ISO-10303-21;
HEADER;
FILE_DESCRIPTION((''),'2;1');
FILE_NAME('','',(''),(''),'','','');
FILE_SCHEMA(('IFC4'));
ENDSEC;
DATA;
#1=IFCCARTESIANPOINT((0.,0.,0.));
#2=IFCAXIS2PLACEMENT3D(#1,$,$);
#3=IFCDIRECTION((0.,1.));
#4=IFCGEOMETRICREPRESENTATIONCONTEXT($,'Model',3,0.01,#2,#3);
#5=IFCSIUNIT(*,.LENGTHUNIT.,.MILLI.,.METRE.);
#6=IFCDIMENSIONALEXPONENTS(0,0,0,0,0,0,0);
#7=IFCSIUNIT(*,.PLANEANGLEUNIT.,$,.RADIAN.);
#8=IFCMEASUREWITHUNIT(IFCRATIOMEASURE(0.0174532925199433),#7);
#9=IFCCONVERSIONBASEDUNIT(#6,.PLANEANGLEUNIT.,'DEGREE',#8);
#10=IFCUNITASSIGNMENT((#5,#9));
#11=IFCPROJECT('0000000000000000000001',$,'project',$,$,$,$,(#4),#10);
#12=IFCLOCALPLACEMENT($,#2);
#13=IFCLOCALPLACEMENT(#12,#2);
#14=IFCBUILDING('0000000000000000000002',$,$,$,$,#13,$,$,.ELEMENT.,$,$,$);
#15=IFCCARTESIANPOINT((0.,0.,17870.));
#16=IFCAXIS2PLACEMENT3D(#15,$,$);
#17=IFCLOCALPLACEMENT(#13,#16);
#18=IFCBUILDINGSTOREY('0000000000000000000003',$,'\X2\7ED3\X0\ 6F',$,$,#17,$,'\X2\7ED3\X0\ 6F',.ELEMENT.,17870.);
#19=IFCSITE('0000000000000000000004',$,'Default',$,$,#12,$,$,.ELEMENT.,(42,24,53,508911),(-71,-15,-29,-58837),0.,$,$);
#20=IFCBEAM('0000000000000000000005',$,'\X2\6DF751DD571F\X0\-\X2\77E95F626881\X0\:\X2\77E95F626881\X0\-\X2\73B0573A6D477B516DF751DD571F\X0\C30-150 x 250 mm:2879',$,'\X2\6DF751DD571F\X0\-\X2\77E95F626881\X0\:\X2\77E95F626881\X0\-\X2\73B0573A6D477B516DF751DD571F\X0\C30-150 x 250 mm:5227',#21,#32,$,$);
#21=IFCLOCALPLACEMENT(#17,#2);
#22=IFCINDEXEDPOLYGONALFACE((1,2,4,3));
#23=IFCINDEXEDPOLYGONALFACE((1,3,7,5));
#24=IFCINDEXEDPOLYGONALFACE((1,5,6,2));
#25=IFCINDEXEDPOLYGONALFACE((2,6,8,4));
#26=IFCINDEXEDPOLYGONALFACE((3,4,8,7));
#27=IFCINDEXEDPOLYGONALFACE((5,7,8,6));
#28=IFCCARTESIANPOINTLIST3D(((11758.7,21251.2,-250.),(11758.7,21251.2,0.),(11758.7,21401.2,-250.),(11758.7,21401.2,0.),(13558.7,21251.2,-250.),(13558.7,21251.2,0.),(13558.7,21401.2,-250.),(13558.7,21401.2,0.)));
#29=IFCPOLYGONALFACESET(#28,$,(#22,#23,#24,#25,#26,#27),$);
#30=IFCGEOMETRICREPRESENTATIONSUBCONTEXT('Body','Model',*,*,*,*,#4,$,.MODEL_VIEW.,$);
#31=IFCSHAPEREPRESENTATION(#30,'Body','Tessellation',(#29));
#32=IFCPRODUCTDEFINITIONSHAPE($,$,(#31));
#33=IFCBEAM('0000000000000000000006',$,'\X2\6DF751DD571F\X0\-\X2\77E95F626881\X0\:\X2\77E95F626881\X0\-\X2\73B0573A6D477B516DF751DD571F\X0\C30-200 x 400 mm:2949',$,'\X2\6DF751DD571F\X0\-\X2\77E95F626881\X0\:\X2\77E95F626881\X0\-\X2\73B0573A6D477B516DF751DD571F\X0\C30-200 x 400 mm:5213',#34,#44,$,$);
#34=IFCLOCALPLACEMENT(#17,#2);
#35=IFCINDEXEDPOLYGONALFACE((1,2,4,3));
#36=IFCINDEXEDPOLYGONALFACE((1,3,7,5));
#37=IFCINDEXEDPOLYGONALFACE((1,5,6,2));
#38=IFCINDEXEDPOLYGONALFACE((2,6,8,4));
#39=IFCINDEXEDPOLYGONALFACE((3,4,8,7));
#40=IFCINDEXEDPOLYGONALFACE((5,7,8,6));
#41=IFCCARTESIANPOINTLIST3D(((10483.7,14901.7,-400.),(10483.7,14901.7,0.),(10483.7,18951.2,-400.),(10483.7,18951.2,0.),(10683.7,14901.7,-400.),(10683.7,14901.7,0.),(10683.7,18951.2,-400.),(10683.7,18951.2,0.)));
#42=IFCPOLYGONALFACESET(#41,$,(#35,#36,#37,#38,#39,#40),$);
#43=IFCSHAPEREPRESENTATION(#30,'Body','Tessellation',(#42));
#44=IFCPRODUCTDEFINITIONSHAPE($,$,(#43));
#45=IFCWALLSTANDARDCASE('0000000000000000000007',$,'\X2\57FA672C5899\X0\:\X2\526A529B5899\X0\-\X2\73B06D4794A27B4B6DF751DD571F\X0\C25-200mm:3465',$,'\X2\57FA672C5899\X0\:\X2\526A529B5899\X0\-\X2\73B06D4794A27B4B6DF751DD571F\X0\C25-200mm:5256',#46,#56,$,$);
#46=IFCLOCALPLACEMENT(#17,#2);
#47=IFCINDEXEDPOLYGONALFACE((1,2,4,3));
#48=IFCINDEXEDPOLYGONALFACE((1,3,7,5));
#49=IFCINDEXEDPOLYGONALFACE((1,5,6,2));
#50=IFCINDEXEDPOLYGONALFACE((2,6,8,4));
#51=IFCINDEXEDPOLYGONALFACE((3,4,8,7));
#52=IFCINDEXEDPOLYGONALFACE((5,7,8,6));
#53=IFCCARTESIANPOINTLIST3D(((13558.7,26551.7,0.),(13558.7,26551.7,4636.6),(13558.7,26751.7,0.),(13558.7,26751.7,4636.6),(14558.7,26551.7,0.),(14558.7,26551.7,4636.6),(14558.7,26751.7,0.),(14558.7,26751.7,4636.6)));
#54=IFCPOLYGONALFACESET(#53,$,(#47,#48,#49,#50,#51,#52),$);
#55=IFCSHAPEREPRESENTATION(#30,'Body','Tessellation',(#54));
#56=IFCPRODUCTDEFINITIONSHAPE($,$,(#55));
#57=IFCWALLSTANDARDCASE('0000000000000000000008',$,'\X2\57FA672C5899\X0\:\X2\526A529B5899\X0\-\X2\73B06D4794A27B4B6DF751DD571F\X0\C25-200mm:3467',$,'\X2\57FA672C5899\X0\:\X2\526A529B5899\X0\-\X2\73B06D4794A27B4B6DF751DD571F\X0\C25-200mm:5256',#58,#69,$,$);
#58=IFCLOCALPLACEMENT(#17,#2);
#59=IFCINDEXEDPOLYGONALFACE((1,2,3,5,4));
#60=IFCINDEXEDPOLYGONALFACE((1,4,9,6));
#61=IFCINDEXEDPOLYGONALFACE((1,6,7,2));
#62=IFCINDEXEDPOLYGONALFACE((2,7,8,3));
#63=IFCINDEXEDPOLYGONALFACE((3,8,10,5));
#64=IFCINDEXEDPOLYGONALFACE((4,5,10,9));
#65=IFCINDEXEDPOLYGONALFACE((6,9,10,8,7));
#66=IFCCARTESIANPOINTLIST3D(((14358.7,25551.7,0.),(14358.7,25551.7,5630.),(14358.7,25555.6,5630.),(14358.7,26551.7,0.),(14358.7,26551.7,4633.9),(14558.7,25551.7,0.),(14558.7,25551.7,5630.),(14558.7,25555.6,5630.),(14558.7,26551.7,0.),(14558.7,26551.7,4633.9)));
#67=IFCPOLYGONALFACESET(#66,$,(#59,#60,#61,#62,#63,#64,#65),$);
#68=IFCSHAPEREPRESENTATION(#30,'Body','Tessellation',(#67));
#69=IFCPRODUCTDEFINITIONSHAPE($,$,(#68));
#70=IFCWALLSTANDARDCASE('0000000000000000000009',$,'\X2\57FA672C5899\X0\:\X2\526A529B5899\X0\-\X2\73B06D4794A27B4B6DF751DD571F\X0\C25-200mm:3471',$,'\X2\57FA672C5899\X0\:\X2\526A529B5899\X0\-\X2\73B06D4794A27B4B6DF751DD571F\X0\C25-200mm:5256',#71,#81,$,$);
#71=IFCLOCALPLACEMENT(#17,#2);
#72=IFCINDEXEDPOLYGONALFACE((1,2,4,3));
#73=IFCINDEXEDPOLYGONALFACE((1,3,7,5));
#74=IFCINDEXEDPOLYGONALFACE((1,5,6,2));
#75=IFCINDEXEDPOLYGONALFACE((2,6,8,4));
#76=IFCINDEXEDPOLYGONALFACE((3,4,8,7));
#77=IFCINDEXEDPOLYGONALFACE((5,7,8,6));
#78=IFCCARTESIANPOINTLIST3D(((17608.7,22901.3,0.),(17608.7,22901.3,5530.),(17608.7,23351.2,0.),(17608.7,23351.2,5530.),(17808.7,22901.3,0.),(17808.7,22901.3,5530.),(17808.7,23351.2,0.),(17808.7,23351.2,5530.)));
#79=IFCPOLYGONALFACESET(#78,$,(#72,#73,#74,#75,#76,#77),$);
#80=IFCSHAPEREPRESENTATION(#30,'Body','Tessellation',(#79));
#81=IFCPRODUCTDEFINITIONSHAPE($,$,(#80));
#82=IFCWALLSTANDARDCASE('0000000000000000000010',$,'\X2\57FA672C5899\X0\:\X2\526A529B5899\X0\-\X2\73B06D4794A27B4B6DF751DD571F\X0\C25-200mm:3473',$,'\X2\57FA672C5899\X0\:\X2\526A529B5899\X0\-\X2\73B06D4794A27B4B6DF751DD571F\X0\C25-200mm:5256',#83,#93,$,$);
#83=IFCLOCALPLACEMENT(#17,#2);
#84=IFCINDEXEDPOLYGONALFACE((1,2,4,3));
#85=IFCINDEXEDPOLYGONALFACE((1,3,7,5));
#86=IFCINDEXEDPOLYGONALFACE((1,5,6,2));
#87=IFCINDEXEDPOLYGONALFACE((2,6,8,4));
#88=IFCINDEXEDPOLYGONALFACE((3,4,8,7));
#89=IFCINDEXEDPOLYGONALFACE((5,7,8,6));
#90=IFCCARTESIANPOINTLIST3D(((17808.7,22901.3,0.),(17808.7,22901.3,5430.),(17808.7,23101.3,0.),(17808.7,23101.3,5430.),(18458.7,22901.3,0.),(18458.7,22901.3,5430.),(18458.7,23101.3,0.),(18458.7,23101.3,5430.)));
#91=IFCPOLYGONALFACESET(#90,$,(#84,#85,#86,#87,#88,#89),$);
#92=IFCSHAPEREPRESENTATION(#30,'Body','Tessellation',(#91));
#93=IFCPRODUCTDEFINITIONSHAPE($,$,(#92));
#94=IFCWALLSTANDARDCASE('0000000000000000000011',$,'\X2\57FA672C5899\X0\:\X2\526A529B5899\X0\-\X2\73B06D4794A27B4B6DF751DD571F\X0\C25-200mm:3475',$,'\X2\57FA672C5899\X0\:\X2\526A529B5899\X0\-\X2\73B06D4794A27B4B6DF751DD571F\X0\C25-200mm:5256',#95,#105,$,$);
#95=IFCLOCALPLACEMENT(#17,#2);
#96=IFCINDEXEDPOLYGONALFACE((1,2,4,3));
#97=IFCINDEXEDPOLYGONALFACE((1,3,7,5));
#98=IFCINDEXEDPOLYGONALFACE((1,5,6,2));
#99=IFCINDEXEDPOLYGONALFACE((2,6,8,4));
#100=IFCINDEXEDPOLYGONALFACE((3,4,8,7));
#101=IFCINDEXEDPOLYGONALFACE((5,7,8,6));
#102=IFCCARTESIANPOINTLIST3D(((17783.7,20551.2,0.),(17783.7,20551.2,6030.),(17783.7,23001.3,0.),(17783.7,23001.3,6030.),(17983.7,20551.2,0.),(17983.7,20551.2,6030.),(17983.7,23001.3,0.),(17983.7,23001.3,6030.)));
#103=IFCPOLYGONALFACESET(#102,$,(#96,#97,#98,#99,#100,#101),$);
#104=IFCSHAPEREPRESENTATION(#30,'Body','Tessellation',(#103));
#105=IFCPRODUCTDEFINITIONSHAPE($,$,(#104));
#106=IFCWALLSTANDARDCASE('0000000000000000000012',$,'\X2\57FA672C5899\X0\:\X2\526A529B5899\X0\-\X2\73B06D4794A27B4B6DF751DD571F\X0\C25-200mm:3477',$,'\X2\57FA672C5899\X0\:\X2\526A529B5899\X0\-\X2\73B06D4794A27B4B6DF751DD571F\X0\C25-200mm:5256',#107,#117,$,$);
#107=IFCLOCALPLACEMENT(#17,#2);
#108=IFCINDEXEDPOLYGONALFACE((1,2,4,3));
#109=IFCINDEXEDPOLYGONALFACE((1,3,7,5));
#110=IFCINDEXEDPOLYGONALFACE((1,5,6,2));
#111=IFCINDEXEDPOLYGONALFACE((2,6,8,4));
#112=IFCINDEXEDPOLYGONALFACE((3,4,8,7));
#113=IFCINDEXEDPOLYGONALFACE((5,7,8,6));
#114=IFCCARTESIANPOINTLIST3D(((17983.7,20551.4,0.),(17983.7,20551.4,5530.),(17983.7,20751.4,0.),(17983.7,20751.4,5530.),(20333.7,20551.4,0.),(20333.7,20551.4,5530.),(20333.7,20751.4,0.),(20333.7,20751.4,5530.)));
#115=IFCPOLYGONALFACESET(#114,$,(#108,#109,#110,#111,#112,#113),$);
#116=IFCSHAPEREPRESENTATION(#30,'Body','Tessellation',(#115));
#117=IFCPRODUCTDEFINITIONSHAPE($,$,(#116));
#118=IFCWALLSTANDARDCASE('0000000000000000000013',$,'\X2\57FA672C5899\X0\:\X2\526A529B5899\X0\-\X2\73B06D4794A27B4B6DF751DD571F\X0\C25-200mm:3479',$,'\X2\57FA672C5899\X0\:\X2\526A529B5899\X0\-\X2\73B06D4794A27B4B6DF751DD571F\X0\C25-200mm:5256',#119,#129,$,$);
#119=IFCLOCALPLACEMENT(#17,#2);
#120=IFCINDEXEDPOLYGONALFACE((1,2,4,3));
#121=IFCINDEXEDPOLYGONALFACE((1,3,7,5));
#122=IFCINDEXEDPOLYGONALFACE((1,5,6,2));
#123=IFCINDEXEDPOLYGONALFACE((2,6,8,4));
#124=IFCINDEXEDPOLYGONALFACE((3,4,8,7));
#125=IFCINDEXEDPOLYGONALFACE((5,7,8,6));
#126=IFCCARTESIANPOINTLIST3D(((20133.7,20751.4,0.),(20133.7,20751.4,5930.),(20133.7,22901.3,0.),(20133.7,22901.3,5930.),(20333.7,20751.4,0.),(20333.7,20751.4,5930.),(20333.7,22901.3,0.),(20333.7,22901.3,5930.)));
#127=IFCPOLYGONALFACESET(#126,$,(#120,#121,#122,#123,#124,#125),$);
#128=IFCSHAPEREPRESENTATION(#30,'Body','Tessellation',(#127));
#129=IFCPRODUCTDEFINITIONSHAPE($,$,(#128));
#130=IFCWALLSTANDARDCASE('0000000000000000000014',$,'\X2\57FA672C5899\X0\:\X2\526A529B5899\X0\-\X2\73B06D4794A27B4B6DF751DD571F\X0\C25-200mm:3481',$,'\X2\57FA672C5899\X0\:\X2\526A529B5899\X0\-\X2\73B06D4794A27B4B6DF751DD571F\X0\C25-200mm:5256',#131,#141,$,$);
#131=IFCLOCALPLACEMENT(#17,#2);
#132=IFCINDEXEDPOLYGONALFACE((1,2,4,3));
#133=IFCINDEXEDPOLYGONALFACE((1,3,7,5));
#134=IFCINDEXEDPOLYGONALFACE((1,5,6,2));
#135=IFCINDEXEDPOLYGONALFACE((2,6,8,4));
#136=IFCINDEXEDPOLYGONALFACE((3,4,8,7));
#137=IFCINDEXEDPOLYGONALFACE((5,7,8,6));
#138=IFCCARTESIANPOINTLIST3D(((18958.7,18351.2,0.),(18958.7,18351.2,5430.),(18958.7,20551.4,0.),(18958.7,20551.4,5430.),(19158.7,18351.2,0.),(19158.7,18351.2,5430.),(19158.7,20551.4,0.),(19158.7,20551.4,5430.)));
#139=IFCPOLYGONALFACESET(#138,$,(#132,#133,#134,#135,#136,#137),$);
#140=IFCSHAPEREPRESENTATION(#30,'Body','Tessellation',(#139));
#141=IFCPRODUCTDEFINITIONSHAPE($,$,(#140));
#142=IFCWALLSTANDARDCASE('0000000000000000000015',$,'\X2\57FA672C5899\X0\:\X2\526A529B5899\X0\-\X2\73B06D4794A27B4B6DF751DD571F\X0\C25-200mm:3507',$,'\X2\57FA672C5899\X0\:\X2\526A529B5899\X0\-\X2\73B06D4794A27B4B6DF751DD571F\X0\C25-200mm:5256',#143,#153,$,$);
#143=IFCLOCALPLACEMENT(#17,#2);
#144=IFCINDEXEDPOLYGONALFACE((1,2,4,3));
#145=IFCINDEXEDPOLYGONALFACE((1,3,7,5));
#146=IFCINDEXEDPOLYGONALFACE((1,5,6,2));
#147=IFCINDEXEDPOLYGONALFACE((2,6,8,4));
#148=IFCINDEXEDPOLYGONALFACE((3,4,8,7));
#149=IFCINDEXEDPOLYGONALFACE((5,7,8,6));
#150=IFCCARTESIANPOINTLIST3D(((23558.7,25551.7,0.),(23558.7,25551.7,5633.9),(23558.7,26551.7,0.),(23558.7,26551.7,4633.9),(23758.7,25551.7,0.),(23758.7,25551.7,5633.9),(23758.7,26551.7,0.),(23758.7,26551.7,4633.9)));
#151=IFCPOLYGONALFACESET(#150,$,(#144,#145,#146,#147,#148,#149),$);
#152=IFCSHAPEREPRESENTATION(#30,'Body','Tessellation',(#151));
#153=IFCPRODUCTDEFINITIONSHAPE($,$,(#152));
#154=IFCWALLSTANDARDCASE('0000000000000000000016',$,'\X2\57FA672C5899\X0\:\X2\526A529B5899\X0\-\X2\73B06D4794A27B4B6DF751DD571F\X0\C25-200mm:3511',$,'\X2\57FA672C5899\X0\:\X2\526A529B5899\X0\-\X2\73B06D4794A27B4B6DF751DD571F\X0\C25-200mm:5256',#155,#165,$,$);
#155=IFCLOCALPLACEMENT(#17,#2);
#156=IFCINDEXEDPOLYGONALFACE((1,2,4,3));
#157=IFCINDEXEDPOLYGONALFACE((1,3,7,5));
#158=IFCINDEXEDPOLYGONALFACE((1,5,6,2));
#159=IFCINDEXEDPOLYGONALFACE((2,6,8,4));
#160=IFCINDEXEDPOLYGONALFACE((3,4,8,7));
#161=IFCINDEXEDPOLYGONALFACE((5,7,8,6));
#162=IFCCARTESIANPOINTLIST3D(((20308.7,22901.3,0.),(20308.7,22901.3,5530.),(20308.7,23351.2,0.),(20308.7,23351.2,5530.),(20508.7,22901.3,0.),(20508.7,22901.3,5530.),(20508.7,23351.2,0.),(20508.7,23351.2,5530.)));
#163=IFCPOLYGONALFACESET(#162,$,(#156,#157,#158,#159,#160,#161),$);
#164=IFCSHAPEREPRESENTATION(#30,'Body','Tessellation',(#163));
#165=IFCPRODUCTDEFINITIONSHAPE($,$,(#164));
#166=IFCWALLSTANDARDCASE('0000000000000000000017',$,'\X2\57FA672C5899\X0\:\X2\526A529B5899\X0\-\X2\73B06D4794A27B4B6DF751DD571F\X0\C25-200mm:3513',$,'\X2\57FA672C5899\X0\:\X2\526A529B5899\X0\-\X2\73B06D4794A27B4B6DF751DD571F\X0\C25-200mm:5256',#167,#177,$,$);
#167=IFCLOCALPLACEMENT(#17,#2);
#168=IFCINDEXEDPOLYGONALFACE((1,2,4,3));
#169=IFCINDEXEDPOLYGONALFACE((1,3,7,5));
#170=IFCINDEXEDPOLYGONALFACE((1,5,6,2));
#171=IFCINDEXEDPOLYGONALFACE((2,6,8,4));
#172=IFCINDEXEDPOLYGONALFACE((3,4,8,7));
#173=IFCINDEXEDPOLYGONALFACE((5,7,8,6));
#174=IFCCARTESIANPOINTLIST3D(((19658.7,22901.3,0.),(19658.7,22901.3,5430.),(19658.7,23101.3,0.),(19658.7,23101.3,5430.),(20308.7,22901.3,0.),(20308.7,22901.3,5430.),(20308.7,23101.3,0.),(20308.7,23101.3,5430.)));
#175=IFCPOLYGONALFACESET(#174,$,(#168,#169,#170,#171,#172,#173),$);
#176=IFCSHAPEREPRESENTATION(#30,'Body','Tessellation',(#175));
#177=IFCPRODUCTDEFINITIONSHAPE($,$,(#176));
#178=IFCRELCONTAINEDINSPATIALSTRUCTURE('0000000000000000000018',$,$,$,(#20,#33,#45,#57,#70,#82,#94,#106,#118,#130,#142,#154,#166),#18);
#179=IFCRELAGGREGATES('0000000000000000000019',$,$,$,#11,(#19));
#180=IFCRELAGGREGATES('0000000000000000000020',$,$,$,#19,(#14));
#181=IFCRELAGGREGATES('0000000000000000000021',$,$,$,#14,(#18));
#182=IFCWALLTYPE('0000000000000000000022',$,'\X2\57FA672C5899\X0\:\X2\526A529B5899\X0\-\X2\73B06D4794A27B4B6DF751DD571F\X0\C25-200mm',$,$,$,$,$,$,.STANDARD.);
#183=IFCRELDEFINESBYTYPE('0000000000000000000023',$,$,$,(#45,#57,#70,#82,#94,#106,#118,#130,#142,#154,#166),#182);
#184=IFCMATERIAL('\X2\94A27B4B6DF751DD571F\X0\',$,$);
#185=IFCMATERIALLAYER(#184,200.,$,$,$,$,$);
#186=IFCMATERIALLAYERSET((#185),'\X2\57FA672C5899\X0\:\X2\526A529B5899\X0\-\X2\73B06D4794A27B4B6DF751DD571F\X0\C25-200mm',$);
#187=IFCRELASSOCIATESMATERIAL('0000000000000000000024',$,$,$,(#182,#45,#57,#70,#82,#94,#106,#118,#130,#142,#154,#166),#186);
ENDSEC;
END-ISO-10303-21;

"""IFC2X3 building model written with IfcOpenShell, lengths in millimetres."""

from ifc_helpers import new_model, entity, si_unit, converted_unit, direction, frame, frame_2d, origin, place, context, subcontext, project, spatial, rectangle, extrude, clip, halfspace, material, layer, layer_set, layer_usage, type_object, element, save


model = new_model("IFC2X3")

# Units and contexts
model_context = context("Model", 3, precision=0.01, world=origin(), true_north=direction((0.0, 1.0)))
body_context = subcontext(model_context, "Body", "Model", "MODEL_VIEW")
ifc_project = project(units=[si_unit("LENGTHUNIT", "METRE", prefix="MILLI"), converted_unit("PLANEANGLEUNIT", "DEGREE", entity("IfcRatioMeasure", 0.0174532925199433), si_unit("PLANEANGLEUNIT", "RADIAN"), dimensions=[0, 0, 0, 0, 0, 0, 0])], contexts=[model_context])

# Site, building, storey
site_placement = place(None, origin())
site = spatial("IfcSite", under=ifc_project, at=site_placement, Name="Default", CompositionType="ELEMENT", RefLatitude=(42, 24, 53, 508911), RefLongitude=(-71, -15, -29, -58837), RefElevation=0.0)
building_placement = place(site_placement, origin())
building = spatial("IfcBuilding", under=site, at=building_placement, CompositionType="ELEMENT")
storey_placement = place(building_placement, frame((0.0, 0.0, 17870.0)))
storey = spatial("IfcBuildingStorey", under=building, at=storey_placement, Name="结 6F", LongName="结 6F", CompositionType="ELEMENT", Elevation=17870.0)

# Beams
beam_1_placement = place(storey_placement, frame((11683.7, 21326.2, 0.0)))
element("IfcBeam", 1, at=beam_1_placement, inside=storey, Name="混凝土-矩形梁:矩形梁-现场浇筑混凝土C30-150 x 250 mm:2879", ObjectType="混凝土-矩形梁:矩形梁-现场浇筑混凝土C30-150 x 250 mm:5227", context=body_context, shape_type="SweptSolid", body=[
    extrude(rectangle(XDim=250.0, YDim=150.0, at=frame_2d((0.0, 0.0), x_axis=(1.0, 0.0))), frame((75.0, 0.0, -125.0), z_axis=(1.0, 0.0, 0.0), x_axis=(0.0, 0.0, -1.0)), (0.0, 0.0, 1.0), 1800.0),
])
ifc_material = material(Name="钢筋混凝土")
beam_2_placement = place(storey_placement, frame((10583.7, 19051.2, 0.0), z_axis=(0.0, 0.0, 1.0), x_axis=(0.0, -1.0, 0.0)))
element("IfcBeam", 2, at=beam_2_placement, inside=storey, Name="混凝土-矩形梁:矩形梁-现场浇筑混凝土C30-200 x 400 mm:2949", ObjectType="混凝土-矩形梁:矩形梁-现场浇筑混凝土C30-200 x 400 mm:5213", context=body_context, shape_type="SweptSolid", body=[
    extrude(rectangle(XDim=400.0, YDim=200.0, at=frame_2d((0.0, 0.0), x_axis=(1.0, 0.0))), frame((100.0, 0.0, -200.0), z_axis=(1.0, 0.0, 0.0), x_axis=(0.0, 0.0, -1.0)), (0.0, 0.0, 1.0), 4049.5),
])

# Walls
ifc_layer = layer(ifc_material, 200.0)
ifc_layer_set = layer_set([ifc_layer], Name="基本墙:剪力墙-现浇钢筋混凝土C25-200mm")
ifc_layer_usage_1 = layer_usage(ifc_layer_set, "AXIS2", "NEGATIVE", 100.0)
wall_type = type_object("IfcWallType", Name="基本墙:剪力墙-现浇钢筋混凝土C25-200mm", PredefinedType="STANDARD", material=ifc_layer_set)
wall_1_placement = place(storey_placement, frame((13558.7, 26651.7, 0.0)))
element("IfcWallStandardCase", 3, at=wall_1_placement, inside=storey, type_object=wall_type, material=ifc_layer_usage_1, Name="基本墙:剪力墙-现浇钢筋混凝土C25-200mm:3465", ObjectType="基本墙:剪力墙-现浇钢筋混凝土C25-200mm:5256", context=body_context, shape_type="SweptSolid", body=[
    extrude(rectangle(XDim=1000.0, YDim=200.0, at=frame_2d((500.0, 0.0), x_axis=(-1.0, 0.0))), origin(), (0.0, 0.0, 1.0), 4636.6),
])
ifc_layer_usage_2 = layer_usage(ifc_layer_set, "AXIS2", "NEGATIVE", 100.0)
wall_2_placement = place(storey_placement, frame((14458.7, 26551.7, 0.0), z_axis=(0.0, 0.0, 1.0), x_axis=(0.0, -1.0, 0.0)))
element("IfcWallStandardCase", 4, at=wall_2_placement, inside=storey, type_object=wall_type, material=ifc_layer_usage_2, Name="基本墙:剪力墙-现浇钢筋混凝土C25-200mm:3467", ObjectType="基本墙:剪力墙-现浇钢筋混凝土C25-200mm:5256", context=body_context, shape_type="Clipping", body=[
    clip(extrude(rectangle(XDim=1000.0, YDim=200.0, at=frame_2d((500.0, 0.0), x_axis=(-1.0, 0.0))), origin(), (0.0, 0.0, 1.0), 5630.0), halfspace(frame((0.0, -100.0, 4633.9), z_axis=(-0.707107, 0.0, 0.707107), x_axis=(0.0, 1.0, 0.0)), False)),
])
ifc_layer_usage_3 = layer_usage(ifc_layer_set, "AXIS2", "NEGATIVE", 100.0)
wall_3_placement = place(storey_placement, frame((17708.7, 23351.2, 0.0), z_axis=(0.0, 0.0, 1.0), x_axis=(0.0, -1.0, 0.0)))
element("IfcWallStandardCase", 5, at=wall_3_placement, inside=storey, type_object=wall_type, material=ifc_layer_usage_3, Name="基本墙:剪力墙-现浇钢筋混凝土C25-200mm:3471", ObjectType="基本墙:剪力墙-现浇钢筋混凝土C25-200mm:5256", context=body_context, shape_type="SweptSolid", body=[
    extrude(rectangle(XDim=449.9, YDim=200.0, at=frame_2d((225.0, 0.0), x_axis=(-1.0, 0.0))), origin(), (0.0, 0.0, 1.0), 5530.0),
])
ifc_layer_usage_4 = layer_usage(ifc_layer_set, "AXIS2", "NEGATIVE", 100.0)
wall_4_placement = place(storey_placement, frame((17808.7, 23001.3, 0.0)))
element("IfcWallStandardCase", 6, at=wall_4_placement, inside=storey, type_object=wall_type, material=ifc_layer_usage_4, Name="基本墙:剪力墙-现浇钢筋混凝土C25-200mm:3473", ObjectType="基本墙:剪力墙-现浇钢筋混凝土C25-200mm:5256", context=body_context, shape_type="SweptSolid", body=[
    extrude(rectangle(XDim=650.0, YDim=200.0, at=frame_2d((325.0, 0.0), x_axis=(-1.0, 0.0))), origin(), (0.0, 0.0, 1.0), 5430.0),
])
ifc_layer_usage_5 = layer_usage(ifc_layer_set, "AXIS2", "NEGATIVE", 100.0)
wall_5_placement = place(storey_placement, frame((17883.7, 20551.2, 0.0), z_axis=(0.0, 0.0, 1.0), x_axis=(0.0, 1.0, 0.0)))
element("IfcWallStandardCase", 7, at=wall_5_placement, inside=storey, type_object=wall_type, material=ifc_layer_usage_5, Name="基本墙:剪力墙-现浇钢筋混凝土C25-200mm:3475", ObjectType="基本墙:剪力墙-现浇钢筋混凝土C25-200mm:5256", context=body_context, shape_type="SweptSolid", body=[
    extrude(rectangle(XDim=2450.1, YDim=200.0, at=frame_2d((1225.0, 0.0), x_axis=(-1.0, 0.0))), origin(), (0.0, 0.0, 1.0), 6030.0),
])
ifc_layer_usage_6 = layer_usage(ifc_layer_set, "AXIS2", "NEGATIVE", 100.0)
wall_6_placement = place(storey_placement, frame((17983.7, 20651.4, 0.0)))
element("IfcWallStandardCase", 8, at=wall_6_placement, inside=storey, type_object=wall_type, material=ifc_layer_usage_6, Name="基本墙:剪力墙-现浇钢筋混凝土C25-200mm:3477", ObjectType="基本墙:剪力墙-现浇钢筋混凝土C25-200mm:5256", context=body_context, shape_type="SweptSolid", body=[
    extrude(rectangle(XDim=2350.0, YDim=200.0, at=frame_2d((1175.0, 0.0), x_axis=(-1.0, 0.0))), origin(), (0.0, 0.0, 1.0), 5530.0),
])
ifc_layer_usage_7 = layer_usage(ifc_layer_set, "AXIS2", "NEGATIVE", 100.0)
wall_7_placement = place(storey_placement, frame((20233.7, 20751.4, 0.0), z_axis=(0.0, 0.0, 1.0), x_axis=(0.0, 1.0, 0.0)))
element("IfcWallStandardCase", 9, at=wall_7_placement, inside=storey, type_object=wall_type, material=ifc_layer_usage_7, Name="基本墙:剪力墙-现浇钢筋混凝土C25-200mm:3479", ObjectType="基本墙:剪力墙-现浇钢筋混凝土C25-200mm:5256", context=body_context, shape_type="SweptSolid", body=[
    extrude(rectangle(XDim=2149.9, YDim=200.0, at=frame_2d((1075.0, 0.0), x_axis=(-1.0, 0.0))), origin(), (0.0, 0.0, 1.0), 5930.0),
])
ifc_layer_usage_8 = layer_usage(ifc_layer_set, "AXIS2", "NEGATIVE", 100.0)
wall_8_placement = place(storey_placement, frame((19058.7, 20551.4, 0.0), z_axis=(0.0, 0.0, 1.0), x_axis=(0.0, -1.0, 0.0)))
element("IfcWallStandardCase", 10, at=wall_8_placement, inside=storey, type_object=wall_type, material=ifc_layer_usage_8, Name="基本墙:剪力墙-现浇钢筋混凝土C25-200mm:3481", ObjectType="基本墙:剪力墙-现浇钢筋混凝土C25-200mm:5256", context=body_context, shape_type="SweptSolid", body=[
    extrude(rectangle(XDim=2200.2, YDim=200.0, at=frame_2d((1100.1, 0.0), x_axis=(-1.0, 0.0))), origin(), (0.0, 0.0, 1.0), 5430.0),
])
ifc_layer_usage_9 = layer_usage(ifc_layer_set, "AXIS2", "POSITIVE", -100.0)
wall_9_placement = place(storey_placement, frame((23658.7, 26551.7, 0.0), z_axis=(0.0, 0.0, 1.0), x_axis=(0.0, -1.0, 0.0)))
element("IfcWallStandardCase", 11, at=wall_9_placement, inside=storey, type_object=wall_type, material=ifc_layer_usage_9, Name="基本墙:剪力墙-现浇钢筋混凝土C25-200mm:3507", ObjectType="基本墙:剪力墙-现浇钢筋混凝土C25-200mm:5256", context=body_context, shape_type="Clipping", body=[
    clip(extrude(rectangle(XDim=1000.0, YDim=200.0, at=frame_2d((500.0, 0.0), x_axis=(-1.0, 0.0))), origin(), (0.0, 0.0, 1.0), 5633.9), halfspace(frame((0.0, -100.0, 4633.9), z_axis=(-0.707107, 0.0, 0.707107), x_axis=(0.0, 1.0, 0.0)), False)),
])
ifc_layer_usage_10 = layer_usage(ifc_layer_set, "AXIS2", "POSITIVE", -100.0)
wall_10_placement = place(storey_placement, frame((20408.7, 23351.2, 0.0), z_axis=(0.0, 0.0, 1.0), x_axis=(0.0, -1.0, 0.0)))
element("IfcWallStandardCase", 12, at=wall_10_placement, inside=storey, type_object=wall_type, material=ifc_layer_usage_10, Name="基本墙:剪力墙-现浇钢筋混凝土C25-200mm:3511", ObjectType="基本墙:剪力墙-现浇钢筋混凝土C25-200mm:5256", context=body_context, shape_type="SweptSolid", body=[
    extrude(rectangle(XDim=449.9, YDim=200.0, at=frame_2d((225.0, 0.0), x_axis=(-1.0, 0.0))), origin(), (0.0, 0.0, 1.0), 5530.0),
])
ifc_layer_usage_11 = layer_usage(ifc_layer_set, "AXIS2", "POSITIVE", -100.0)
wall_11_placement = place(storey_placement, frame((20308.7, 23001.3, 0.0), z_axis=(0.0, 0.0, 1.0), x_axis=(-1.0, 0.0, 0.0)))
element("IfcWallStandardCase", 13, at=wall_11_placement, inside=storey, type_object=wall_type, material=ifc_layer_usage_11, Name="基本墙:剪力墙-现浇钢筋混凝土C25-200mm:3513", ObjectType="基本墙:剪力墙-现浇钢筋混凝土C25-200mm:5256", context=body_context, shape_type="SweptSolid", body=[
    extrude(rectangle(XDim=650.0, YDim=200.0, at=frame_2d((325.0, 0.0), x_axis=(-1.0, 0.0))), origin(), (0.0, 0.0, 1.0), 5430.0),
])

save(model, "model.ifc")
